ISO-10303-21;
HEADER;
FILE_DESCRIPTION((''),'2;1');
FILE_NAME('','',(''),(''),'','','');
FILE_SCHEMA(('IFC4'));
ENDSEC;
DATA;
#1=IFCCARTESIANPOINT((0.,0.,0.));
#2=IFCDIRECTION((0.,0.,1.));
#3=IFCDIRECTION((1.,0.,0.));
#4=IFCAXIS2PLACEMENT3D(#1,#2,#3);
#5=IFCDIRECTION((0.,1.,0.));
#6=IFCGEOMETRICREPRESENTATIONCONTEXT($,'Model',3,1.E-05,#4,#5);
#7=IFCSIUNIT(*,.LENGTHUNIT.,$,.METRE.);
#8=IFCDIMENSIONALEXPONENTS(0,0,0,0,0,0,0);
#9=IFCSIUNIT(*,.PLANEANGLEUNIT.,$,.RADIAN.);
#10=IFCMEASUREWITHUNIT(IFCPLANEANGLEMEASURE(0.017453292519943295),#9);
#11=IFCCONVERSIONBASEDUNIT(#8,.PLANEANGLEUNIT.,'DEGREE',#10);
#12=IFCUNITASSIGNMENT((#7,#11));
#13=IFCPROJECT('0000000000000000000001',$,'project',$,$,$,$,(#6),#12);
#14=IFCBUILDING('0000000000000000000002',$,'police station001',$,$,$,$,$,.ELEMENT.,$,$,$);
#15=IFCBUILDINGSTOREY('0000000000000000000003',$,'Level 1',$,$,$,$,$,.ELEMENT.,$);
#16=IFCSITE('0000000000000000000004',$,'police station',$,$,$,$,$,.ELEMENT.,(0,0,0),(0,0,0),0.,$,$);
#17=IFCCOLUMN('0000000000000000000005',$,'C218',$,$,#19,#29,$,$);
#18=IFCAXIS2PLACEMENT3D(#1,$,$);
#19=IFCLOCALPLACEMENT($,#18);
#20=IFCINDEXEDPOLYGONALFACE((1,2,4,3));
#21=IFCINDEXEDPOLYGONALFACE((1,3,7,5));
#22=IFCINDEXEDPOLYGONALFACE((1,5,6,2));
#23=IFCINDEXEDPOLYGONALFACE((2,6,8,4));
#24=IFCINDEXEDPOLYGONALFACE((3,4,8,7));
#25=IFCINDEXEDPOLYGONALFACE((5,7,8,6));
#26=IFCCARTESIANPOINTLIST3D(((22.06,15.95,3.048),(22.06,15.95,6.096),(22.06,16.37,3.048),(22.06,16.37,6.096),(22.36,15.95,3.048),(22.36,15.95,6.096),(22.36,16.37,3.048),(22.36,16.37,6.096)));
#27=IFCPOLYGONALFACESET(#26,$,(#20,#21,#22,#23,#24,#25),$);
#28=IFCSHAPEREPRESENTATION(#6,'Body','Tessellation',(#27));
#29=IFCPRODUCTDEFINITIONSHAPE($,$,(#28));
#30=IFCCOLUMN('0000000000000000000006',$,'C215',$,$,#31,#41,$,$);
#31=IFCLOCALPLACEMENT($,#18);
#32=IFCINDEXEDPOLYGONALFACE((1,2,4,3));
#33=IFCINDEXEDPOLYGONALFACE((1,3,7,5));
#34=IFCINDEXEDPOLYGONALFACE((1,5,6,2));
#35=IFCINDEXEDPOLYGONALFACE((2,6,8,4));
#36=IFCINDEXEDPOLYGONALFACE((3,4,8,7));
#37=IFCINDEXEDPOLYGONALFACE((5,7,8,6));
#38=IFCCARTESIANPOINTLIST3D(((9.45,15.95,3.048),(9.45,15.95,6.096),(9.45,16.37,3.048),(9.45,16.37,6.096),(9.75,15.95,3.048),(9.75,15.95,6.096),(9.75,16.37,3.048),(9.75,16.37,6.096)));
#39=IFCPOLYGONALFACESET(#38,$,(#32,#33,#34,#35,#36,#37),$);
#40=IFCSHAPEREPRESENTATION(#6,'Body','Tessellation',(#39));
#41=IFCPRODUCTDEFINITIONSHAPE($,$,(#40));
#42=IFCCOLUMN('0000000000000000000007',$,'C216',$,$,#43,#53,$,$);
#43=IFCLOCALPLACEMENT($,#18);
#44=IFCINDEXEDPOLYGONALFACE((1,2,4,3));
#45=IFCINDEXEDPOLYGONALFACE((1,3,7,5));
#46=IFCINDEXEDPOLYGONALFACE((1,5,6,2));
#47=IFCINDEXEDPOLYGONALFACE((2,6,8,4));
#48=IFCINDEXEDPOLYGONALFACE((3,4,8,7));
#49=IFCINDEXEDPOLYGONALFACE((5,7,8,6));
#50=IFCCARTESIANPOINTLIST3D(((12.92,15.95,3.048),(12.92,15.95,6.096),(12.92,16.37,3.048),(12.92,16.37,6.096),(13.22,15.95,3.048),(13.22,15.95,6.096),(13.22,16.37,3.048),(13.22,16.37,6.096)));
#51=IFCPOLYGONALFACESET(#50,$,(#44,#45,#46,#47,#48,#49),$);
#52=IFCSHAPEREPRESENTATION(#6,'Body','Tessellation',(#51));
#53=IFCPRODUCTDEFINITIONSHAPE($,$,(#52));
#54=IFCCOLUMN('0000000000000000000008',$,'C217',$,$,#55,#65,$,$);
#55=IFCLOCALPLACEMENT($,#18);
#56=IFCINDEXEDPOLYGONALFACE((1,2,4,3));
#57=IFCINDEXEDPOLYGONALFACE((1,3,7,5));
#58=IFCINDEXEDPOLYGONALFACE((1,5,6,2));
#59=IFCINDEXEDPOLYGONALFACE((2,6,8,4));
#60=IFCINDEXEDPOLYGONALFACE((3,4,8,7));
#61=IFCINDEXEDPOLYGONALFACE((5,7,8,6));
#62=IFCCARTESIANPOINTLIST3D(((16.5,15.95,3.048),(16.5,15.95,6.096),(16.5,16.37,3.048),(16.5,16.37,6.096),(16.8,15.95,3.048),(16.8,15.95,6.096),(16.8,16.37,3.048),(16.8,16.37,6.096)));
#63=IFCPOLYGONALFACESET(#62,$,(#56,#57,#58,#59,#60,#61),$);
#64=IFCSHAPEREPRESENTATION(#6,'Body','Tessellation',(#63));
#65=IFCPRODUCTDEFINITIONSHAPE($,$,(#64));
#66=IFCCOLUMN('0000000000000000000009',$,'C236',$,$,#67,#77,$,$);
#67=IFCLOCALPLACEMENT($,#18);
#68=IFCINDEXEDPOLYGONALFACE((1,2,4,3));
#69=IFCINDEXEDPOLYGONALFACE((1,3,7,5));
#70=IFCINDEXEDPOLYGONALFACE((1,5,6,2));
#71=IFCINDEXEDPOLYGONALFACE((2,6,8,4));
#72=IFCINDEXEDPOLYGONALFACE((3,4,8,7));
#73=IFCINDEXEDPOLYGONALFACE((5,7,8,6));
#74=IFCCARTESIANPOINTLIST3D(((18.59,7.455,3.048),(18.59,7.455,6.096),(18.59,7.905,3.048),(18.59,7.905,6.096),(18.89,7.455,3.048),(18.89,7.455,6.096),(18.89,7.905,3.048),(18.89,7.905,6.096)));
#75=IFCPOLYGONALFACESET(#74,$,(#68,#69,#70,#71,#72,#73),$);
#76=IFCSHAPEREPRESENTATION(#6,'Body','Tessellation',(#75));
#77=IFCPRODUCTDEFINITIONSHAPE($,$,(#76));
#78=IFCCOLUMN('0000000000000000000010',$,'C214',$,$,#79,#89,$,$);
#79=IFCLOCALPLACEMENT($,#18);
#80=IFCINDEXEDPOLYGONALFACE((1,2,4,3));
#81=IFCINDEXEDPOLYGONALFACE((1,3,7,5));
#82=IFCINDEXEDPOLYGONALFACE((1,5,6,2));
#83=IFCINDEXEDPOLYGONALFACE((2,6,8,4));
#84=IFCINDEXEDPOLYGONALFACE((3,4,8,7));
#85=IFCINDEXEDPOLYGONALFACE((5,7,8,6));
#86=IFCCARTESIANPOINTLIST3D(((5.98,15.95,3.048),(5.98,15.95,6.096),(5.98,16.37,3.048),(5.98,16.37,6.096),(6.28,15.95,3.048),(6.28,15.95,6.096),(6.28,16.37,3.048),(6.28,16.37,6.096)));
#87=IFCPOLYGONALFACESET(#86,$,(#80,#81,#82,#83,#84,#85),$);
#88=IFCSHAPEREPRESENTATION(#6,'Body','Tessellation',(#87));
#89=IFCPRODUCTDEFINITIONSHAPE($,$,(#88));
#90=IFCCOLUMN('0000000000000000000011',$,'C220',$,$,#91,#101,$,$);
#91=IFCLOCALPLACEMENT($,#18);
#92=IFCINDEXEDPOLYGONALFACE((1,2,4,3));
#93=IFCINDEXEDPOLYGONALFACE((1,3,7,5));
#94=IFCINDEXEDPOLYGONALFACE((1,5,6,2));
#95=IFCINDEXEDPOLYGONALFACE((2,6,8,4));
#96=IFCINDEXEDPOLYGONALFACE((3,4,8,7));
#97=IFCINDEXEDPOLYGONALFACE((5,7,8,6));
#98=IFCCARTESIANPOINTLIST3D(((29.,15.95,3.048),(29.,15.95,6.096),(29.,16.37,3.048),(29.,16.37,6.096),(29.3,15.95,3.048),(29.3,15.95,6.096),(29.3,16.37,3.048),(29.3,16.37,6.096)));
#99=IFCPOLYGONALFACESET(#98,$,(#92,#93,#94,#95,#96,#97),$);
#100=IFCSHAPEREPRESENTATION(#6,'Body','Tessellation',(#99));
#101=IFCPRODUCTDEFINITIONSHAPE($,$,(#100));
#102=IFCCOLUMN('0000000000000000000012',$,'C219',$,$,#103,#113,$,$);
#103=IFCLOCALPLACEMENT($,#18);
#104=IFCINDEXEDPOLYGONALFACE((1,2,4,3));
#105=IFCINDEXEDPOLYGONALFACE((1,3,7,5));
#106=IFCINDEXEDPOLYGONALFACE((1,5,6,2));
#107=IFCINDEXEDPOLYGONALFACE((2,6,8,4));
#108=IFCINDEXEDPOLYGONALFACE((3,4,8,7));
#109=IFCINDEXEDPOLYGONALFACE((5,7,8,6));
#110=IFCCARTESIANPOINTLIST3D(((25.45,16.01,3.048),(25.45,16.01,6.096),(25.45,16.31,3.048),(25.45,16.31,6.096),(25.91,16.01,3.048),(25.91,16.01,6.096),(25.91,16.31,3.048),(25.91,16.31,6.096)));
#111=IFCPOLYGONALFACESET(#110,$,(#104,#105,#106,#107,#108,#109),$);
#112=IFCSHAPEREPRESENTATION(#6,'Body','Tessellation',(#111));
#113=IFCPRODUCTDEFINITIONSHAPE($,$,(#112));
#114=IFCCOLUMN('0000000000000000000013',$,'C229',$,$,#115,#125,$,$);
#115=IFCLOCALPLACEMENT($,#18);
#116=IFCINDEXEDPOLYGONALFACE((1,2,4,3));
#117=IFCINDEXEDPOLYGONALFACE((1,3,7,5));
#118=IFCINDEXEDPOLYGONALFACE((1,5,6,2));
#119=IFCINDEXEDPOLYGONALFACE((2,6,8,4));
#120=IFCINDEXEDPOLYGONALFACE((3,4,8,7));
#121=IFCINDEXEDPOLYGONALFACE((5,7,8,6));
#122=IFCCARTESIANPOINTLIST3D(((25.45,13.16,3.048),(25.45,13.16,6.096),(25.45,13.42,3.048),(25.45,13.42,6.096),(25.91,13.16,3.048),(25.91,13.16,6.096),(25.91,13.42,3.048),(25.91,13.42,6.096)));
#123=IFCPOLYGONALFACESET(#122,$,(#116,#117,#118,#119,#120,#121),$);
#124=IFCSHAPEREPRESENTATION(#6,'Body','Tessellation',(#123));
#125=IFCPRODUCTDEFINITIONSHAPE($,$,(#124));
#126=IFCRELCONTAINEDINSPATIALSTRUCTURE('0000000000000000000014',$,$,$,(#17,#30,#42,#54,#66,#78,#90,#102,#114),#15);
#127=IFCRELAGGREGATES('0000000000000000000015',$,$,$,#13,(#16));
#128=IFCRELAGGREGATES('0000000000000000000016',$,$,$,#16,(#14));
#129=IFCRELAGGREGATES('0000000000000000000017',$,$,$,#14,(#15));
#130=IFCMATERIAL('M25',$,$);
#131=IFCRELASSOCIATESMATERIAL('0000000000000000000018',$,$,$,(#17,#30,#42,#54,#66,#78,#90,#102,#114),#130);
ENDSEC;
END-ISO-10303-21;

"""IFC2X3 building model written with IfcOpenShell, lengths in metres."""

from ifc_helpers import new_model, entity, si_unit, converted_unit, direction, frame, frame_2d, origin_with_axes, place, context, project, spatial, rectangle, extrude, material, element, save


model = new_model("IFC2X3")

# Units and contexts
model_context = context("Model", 3, precision=1e-05, world=origin_with_axes(), true_north=direction((0.0, 1.0, 0.0)))
ifc_project = project(units=[si_unit("LENGTHUNIT", "METRE"), converted_unit("PLANEANGLEUNIT", "DEGREE", entity("IfcPlaneAngleMeasure", 0.017453292519943295), si_unit("PLANEANGLEUNIT", "RADIAN"), dimensions=[0, 0, 0, 0, 0, 0, 0])], contexts=[model_context])

# Site, building, storey
site = spatial("IfcSite", under=ifc_project, Name="police station", CompositionType="ELEMENT", RefLatitude=(0, 0, 0), RefLongitude=(0, 0, 0), RefElevation=0.0)
building = spatial("IfcBuilding", under=site, Name="police station001", CompositionType="ELEMENT")
storey = spatial("IfcBuildingStorey", under=building, Name="Level 1", CompositionType="ELEMENT")

# Columns
ifc_material = material(Name="M25")
placement = place(None, origin_with_axes())
element("IfcColumn", 1, at=placement, inside=storey, material=ifc_material, Name="C218", context=model_context, shape_type="SweptSolid", body=[
    extrude(rectangle(XDim=0.3, YDim=0.42, at=frame_2d((0.0, 0.0), x_axis=(1.0, 0.0, 0.0))), frame((22.21, 16.16, 3.048), z_axis=(0.0, 0.0, 1.0), x_axis=(1.0, 0.0, 0.0)), (0.0, 0.0, 1.0), 3.048),
])
element("IfcColumn", 2, at=placement, inside=storey, material=ifc_material, Name="C215", context=model_context, shape_type="SweptSolid", body=[
    extrude(rectangle(XDim=0.3, YDim=0.42, at=frame_2d((0.0, 0.0), x_axis=(1.0, 0.0, 0.0))), frame((9.6, 16.16, 3.048), z_axis=(0.0, 0.0, 1.0), x_axis=(1.0, 0.0, 0.0)), (0.0, 0.0, 1.0), 3.048),
])
element("IfcColumn", 3, at=placement, inside=storey, material=ifc_material, Name="C216", context=model_context, shape_type="SweptSolid", body=[
    extrude(rectangle(XDim=0.3, YDim=0.42, at=frame_2d((0.0, 0.0), x_axis=(1.0, 0.0, 0.0))), frame((13.07, 16.16, 3.048), z_axis=(0.0, 0.0, 1.0), x_axis=(1.0, 0.0, 0.0)), (0.0, 0.0, 1.0), 3.048),
])
element("IfcColumn", 4, at=placement, inside=storey, material=ifc_material, Name="C217", context=model_context, shape_type="SweptSolid", body=[
    extrude(rectangle(XDim=0.3, YDim=0.42, at=frame_2d((0.0, 0.0), x_axis=(1.0, 0.0, 0.0))), frame((16.65, 16.16, 3.048), z_axis=(0.0, 0.0, 1.0), x_axis=(1.0, 0.0, 0.0)), (0.0, 0.0, 1.0), 3.048),
])
element("IfcColumn", 5, at=placement, inside=storey, material=ifc_material, Name="C236", context=model_context, shape_type="SweptSolid", body=[
    extrude(rectangle(XDim=0.3, YDim=0.45, at=frame_2d((0.0, 0.0), x_axis=(1.0, 0.0, 0.0))), frame((18.74, 7.68, 3.048), z_axis=(0.0, 0.0, 1.0), x_axis=(1.0, 0.0, 0.0)), (0.0, 0.0, 1.0), 3.048),
])
element("IfcColumn", 6, at=placement, inside=storey, material=ifc_material, Name="C214", context=model_context, shape_type="SweptSolid", body=[
    extrude(rectangle(XDim=0.3, YDim=0.42, at=frame_2d((0.0, 0.0), x_axis=(1.0, 0.0, 0.0))), frame((6.13, 16.16, 3.048), z_axis=(0.0, 0.0, 1.0), x_axis=(1.0, 0.0, 0.0)), (0.0, 0.0, 1.0), 3.048),
])
element("IfcColumn", 7, at=placement, inside=storey, material=ifc_material, Name="C220", context=model_context, shape_type="SweptSolid", body=[
    extrude(rectangle(XDim=0.3, YDim=0.42, at=frame_2d((0.0, 0.0), x_axis=(1.0, 0.0, 0.0))), frame((29.15, 16.16, 3.048), z_axis=(0.0, 0.0, 1.0), x_axis=(1.0, 0.0, 0.0)), (0.0, 0.0, 1.0), 3.048),
])
element("IfcColumn", 8, at=placement, inside=storey, material=ifc_material, Name="C219", context=model_context, shape_type="SweptSolid", body=[
    extrude(rectangle(XDim=0.46, YDim=0.3, at=frame_2d((0.0, 0.0), x_axis=(1.0, 0.0, 0.0))), frame((25.68, 16.16, 3.048), z_axis=(0.0, 0.0, 1.0), x_axis=(1.0, 0.0, 0.0)), (0.0, 0.0, 1.0), 3.048),
])
element("IfcColumn", 9, at=placement, inside=storey, material=ifc_material, Name="C229", context=model_context, shape_type="SweptSolid", body=[
    extrude(rectangle(XDim=0.46, YDim=0.26, at=frame_2d((0.0, 0.0), x_axis=(1.0, 0.0, 0.0))), frame((25.68, 13.29, 3.048), z_axis=(0.0, 0.0, 1.0), x_axis=(1.0, 0.0, 0.0)), (0.0, 0.0, 1.0), 3.048),
])

save(model, "model.ifc")
